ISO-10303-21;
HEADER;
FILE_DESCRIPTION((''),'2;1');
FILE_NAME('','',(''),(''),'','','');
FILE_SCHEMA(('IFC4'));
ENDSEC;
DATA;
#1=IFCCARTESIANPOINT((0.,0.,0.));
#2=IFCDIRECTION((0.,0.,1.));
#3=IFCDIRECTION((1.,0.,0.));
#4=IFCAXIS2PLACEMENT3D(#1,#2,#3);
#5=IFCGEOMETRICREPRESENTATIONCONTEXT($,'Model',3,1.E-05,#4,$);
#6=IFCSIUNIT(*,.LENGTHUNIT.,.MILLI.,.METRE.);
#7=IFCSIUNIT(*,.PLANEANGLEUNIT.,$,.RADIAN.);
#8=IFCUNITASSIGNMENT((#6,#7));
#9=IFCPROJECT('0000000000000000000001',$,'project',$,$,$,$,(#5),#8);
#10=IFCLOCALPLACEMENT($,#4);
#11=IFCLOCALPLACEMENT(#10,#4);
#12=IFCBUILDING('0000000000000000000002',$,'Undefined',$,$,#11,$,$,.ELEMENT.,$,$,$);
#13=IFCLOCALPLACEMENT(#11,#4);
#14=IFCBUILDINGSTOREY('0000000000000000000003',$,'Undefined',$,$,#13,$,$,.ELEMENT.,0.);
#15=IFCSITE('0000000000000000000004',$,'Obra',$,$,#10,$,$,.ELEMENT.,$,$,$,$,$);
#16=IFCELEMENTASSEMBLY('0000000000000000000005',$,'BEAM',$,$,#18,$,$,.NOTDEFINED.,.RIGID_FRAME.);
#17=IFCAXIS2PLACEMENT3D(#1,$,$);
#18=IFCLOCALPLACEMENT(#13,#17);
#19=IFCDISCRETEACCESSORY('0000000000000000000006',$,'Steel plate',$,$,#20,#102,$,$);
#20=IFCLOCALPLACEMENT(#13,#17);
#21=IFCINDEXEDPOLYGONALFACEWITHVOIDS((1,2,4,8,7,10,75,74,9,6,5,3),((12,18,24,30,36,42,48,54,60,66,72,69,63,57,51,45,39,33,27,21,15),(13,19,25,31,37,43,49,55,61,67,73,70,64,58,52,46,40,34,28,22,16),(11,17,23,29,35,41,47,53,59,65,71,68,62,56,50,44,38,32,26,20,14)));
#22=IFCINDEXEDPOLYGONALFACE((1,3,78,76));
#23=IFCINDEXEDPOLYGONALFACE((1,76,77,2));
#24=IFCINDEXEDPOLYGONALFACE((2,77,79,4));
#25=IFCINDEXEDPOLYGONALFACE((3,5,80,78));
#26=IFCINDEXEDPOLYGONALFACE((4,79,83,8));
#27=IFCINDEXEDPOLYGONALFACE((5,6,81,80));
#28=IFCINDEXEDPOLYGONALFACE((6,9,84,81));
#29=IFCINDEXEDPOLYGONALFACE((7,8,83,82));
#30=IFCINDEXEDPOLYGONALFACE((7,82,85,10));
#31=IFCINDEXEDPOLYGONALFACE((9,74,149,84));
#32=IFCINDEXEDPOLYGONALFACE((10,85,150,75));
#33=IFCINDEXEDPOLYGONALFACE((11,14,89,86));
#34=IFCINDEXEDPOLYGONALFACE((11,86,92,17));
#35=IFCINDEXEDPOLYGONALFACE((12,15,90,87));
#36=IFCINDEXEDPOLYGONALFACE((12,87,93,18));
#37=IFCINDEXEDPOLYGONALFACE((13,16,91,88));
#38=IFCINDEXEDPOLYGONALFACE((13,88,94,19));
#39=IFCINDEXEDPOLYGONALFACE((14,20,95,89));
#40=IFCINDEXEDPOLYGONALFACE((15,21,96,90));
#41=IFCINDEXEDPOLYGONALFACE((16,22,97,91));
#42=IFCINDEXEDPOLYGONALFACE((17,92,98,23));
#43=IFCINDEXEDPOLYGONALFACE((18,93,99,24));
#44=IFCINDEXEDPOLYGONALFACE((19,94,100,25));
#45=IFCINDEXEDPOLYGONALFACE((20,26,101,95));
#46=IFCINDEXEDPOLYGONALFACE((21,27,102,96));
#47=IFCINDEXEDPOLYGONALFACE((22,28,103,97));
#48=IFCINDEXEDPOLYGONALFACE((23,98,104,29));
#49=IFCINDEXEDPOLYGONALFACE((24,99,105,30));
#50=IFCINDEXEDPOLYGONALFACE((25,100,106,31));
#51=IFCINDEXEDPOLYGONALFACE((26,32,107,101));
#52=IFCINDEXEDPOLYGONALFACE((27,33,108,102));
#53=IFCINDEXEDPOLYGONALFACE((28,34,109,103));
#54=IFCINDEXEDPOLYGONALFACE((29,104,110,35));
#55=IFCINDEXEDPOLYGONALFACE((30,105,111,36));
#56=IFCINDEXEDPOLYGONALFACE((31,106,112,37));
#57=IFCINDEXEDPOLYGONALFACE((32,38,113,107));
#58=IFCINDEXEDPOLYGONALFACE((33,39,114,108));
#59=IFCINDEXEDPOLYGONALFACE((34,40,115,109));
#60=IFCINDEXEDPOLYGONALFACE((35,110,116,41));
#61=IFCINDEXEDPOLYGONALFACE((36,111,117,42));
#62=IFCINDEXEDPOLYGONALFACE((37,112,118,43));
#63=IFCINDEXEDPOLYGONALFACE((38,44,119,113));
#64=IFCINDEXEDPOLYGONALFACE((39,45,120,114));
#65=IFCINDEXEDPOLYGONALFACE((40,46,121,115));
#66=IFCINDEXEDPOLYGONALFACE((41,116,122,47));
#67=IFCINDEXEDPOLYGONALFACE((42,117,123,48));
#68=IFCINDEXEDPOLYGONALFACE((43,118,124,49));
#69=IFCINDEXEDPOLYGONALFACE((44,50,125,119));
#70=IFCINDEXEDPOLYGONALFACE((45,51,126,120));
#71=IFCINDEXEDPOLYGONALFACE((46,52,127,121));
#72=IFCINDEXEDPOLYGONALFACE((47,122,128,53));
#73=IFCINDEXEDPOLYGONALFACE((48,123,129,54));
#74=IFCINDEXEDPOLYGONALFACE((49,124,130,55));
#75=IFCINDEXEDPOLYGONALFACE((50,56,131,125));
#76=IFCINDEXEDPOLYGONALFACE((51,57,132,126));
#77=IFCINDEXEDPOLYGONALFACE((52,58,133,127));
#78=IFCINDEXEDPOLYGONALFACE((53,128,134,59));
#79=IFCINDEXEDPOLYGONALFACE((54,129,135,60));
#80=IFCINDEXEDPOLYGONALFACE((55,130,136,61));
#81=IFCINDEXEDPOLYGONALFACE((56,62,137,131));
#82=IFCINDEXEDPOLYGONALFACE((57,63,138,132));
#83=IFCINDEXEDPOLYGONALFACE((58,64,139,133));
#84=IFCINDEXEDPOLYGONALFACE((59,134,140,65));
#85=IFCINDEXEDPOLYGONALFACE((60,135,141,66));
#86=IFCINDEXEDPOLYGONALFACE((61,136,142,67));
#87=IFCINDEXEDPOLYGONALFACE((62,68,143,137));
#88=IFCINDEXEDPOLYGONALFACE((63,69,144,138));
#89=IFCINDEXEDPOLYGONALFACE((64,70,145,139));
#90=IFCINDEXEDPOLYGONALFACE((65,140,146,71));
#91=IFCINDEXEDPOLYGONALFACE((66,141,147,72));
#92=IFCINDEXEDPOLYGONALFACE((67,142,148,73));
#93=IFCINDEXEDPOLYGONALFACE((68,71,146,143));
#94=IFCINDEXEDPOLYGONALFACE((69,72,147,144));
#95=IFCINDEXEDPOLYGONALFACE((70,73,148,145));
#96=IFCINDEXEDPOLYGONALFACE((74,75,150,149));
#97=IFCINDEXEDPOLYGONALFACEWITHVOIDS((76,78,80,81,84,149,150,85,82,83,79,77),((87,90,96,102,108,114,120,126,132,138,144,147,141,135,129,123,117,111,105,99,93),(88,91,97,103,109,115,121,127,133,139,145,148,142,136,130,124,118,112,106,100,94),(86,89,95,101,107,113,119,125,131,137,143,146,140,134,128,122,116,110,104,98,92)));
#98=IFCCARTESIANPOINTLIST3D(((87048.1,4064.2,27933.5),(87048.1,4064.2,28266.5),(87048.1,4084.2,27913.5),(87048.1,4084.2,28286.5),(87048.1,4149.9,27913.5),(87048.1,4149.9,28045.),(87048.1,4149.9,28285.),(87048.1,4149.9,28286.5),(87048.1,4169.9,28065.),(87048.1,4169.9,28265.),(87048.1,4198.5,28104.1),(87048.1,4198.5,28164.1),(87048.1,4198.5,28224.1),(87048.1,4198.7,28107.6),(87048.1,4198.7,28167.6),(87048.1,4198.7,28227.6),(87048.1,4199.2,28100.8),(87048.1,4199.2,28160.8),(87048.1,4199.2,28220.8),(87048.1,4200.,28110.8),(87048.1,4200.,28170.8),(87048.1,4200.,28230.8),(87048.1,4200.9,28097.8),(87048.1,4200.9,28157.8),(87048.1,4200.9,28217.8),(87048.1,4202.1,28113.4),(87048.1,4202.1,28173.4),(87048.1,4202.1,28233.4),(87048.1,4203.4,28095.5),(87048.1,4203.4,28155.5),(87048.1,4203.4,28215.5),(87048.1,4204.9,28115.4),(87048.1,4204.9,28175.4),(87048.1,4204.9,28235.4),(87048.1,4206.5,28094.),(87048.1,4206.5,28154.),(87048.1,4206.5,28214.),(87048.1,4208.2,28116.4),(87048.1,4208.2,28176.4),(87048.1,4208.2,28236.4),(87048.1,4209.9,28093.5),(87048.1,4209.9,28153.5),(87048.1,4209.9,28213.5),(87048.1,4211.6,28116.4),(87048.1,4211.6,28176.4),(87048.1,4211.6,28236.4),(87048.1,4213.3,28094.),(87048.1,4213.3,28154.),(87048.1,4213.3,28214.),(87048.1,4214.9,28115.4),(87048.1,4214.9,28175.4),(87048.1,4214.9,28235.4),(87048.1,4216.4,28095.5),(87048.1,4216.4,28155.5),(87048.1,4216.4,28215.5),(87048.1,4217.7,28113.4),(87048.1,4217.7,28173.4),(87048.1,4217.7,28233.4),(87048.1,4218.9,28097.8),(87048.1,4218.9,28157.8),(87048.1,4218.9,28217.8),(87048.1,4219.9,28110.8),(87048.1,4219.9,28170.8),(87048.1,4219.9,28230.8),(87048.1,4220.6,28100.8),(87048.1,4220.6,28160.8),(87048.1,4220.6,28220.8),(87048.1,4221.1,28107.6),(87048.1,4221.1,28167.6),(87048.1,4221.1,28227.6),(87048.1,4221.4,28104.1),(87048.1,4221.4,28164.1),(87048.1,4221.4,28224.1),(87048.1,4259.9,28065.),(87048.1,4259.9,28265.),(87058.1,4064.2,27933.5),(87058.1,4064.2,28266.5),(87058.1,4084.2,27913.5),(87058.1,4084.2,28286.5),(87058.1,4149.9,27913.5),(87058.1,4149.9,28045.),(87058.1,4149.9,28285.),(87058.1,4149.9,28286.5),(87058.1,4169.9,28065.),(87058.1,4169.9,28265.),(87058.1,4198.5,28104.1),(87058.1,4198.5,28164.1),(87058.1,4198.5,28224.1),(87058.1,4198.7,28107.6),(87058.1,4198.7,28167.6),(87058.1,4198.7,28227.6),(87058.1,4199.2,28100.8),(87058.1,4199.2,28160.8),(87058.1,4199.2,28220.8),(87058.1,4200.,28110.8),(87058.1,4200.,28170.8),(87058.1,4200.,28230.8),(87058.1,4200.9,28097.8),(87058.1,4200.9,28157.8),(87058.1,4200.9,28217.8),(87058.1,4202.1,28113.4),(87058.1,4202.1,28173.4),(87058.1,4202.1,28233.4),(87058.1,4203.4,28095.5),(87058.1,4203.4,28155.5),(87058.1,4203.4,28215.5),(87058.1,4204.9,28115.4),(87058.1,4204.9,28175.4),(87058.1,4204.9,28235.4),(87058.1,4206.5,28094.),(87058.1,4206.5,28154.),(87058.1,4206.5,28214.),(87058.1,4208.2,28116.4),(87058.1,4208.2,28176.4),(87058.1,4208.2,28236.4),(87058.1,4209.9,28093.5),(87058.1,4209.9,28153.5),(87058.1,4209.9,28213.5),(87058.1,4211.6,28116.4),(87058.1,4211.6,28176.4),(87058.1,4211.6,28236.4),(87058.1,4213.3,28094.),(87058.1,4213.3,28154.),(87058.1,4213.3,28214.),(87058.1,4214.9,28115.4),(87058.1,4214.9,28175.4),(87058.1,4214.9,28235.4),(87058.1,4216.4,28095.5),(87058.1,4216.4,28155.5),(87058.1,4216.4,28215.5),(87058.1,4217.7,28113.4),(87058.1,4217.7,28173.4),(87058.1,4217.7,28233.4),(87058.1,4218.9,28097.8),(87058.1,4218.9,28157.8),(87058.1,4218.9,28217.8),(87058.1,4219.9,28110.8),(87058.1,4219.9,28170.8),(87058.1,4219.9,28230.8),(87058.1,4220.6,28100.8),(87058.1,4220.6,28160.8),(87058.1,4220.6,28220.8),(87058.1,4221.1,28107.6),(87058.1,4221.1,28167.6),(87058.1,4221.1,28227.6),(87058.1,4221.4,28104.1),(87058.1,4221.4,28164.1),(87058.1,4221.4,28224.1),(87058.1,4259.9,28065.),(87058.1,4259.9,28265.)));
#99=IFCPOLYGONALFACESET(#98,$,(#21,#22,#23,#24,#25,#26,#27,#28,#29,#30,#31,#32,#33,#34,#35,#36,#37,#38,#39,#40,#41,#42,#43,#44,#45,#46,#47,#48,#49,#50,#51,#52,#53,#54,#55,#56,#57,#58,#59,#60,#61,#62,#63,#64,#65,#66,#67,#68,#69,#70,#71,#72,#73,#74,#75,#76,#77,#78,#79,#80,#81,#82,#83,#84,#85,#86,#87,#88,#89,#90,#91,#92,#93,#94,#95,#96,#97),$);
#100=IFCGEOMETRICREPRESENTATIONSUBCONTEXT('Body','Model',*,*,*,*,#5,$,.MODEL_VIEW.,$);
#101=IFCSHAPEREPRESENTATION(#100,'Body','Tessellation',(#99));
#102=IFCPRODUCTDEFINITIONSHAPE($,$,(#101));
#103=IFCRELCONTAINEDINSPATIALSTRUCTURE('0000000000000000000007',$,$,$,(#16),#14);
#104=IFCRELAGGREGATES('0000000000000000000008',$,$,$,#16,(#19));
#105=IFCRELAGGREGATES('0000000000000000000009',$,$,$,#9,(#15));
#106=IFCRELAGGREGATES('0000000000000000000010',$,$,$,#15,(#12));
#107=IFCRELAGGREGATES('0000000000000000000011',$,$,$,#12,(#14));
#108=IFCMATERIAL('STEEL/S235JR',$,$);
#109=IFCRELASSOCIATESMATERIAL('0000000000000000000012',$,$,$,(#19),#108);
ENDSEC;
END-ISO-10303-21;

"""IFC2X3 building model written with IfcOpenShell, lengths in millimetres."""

from ifc_helpers import new_model, si_unit, frame, origin_with_axes, origin_2d_with_axis, place, context, subcontext, project, spatial, polyline, circle, outline, extrude, source, transform, mapped, material, element, aggregate, save


model = new_model("IFC2X3")

# Units and contexts
model_context = context("Model", 3, precision=1e-05, world=origin_with_axes())
body_context = subcontext(model_context, "Body", "Model", "MODEL_VIEW")
ifc_project = project(units=[si_unit("LENGTHUNIT", "METRE", prefix="MILLI"), si_unit("PLANEANGLEUNIT", "RADIAN")], contexts=[model_context])

# Site, building, storey
site_placement = place(None, origin_with_axes())
site = spatial("IfcSite", under=ifc_project, at=site_placement, Name="Obra", CompositionType="ELEMENT")
building_placement = place(site_placement, origin_with_axes())
building = spatial("IfcBuilding", under=site, at=building_placement, Name="Undefined", CompositionType="ELEMENT")
storey_placement = place(building_placement, origin_with_axes())
storey = spatial("IfcBuildingStorey", under=building, at=storey_placement, Name="Undefined", CompositionType="ELEMENT", Elevation=0.0)

# Shared definitions
ifc_material = material(Name="STEEL/S235JR")

# Element assembly, discrete accessory, opening
assembly_1_placement = place(storey_placement, origin_with_axes())
assembly_1 = element("IfcElementAssembly", 1, at=assembly_1_placement, inside=storey, Name="BEAM", AssemblyPlace="NOTDEFINED", PredefinedType="RIGID_FRAME")
discrete_accessory_1_placement = place(assembly_1_placement, frame((87053.1, 4064.2, 27933.5), z_axis=(1.0, 0.000014, 0.0), x_axis=(-0.00001, 0.707107, -0.707107)))
discrete_accessory_1 = element("IfcDiscreteAccessory", 2, at=discrete_accessory_1_placement, material=ifc_material, Name="Steel plate", context=body_context, shape_type="SweptSolid", body=[
    extrude(outline(polyline([(0.0, 0.0), (28.3, 0.0), (74.7, 46.5), (-18.2, 139.4), (-18.2, 167.7), (45.4, 231.4), (-96.0, 372.8), (-159.7, 309.1), (-187.9, 309.1), (-189.0, 310.2), (-235.5, 263.8), (-235.5, 235.5), (0.0, 0.0)])), frame((0.0, 0.0, -5.0), z_axis=(0.0, 0.0, 1.0), x_axis=(1.0, 0.0, 0.0)), (0.0, 0.0, 1.0), 10.0),
])
shared_shape_1 = source(origin_with_axes(), body_context, "Body", "SweptSolid", [
    extrude(circle(Radius=11.5, at=origin_2d_with_axis()), frame((0.0, -13.4, 0.0), z_axis=(0.0, 1.0, 0.0), x_axis=(1.0, 0.0, 0.0)), (0.0, 0.0, 1.0), 10.2),
])
opening_1_placement = place(assembly_1_placement, frame((87044.8, 4159.9, 28265.0), z_axis=(-0.000014, 1.0, 0.0), x_axis=(0.0, 0.0, -1.0)))
element("IfcOpeningElement", 3, at=opening_1_placement, cuts=discrete_accessory_1, ObjectType="Opening", context=body_context, shape_type="MappedRepresentation", body=[
    mapped(shared_shape_1, transform((40.0, 0.0, 50.0))),
    mapped(shared_shape_1, transform((100.0, 0.0, 50.0))),
    mapped(shared_shape_1, transform((160.0, 0.0, 50.0))),
])
aggregate(assembly_1, [discrete_accessory_1])

save(model, "model.ifc")
